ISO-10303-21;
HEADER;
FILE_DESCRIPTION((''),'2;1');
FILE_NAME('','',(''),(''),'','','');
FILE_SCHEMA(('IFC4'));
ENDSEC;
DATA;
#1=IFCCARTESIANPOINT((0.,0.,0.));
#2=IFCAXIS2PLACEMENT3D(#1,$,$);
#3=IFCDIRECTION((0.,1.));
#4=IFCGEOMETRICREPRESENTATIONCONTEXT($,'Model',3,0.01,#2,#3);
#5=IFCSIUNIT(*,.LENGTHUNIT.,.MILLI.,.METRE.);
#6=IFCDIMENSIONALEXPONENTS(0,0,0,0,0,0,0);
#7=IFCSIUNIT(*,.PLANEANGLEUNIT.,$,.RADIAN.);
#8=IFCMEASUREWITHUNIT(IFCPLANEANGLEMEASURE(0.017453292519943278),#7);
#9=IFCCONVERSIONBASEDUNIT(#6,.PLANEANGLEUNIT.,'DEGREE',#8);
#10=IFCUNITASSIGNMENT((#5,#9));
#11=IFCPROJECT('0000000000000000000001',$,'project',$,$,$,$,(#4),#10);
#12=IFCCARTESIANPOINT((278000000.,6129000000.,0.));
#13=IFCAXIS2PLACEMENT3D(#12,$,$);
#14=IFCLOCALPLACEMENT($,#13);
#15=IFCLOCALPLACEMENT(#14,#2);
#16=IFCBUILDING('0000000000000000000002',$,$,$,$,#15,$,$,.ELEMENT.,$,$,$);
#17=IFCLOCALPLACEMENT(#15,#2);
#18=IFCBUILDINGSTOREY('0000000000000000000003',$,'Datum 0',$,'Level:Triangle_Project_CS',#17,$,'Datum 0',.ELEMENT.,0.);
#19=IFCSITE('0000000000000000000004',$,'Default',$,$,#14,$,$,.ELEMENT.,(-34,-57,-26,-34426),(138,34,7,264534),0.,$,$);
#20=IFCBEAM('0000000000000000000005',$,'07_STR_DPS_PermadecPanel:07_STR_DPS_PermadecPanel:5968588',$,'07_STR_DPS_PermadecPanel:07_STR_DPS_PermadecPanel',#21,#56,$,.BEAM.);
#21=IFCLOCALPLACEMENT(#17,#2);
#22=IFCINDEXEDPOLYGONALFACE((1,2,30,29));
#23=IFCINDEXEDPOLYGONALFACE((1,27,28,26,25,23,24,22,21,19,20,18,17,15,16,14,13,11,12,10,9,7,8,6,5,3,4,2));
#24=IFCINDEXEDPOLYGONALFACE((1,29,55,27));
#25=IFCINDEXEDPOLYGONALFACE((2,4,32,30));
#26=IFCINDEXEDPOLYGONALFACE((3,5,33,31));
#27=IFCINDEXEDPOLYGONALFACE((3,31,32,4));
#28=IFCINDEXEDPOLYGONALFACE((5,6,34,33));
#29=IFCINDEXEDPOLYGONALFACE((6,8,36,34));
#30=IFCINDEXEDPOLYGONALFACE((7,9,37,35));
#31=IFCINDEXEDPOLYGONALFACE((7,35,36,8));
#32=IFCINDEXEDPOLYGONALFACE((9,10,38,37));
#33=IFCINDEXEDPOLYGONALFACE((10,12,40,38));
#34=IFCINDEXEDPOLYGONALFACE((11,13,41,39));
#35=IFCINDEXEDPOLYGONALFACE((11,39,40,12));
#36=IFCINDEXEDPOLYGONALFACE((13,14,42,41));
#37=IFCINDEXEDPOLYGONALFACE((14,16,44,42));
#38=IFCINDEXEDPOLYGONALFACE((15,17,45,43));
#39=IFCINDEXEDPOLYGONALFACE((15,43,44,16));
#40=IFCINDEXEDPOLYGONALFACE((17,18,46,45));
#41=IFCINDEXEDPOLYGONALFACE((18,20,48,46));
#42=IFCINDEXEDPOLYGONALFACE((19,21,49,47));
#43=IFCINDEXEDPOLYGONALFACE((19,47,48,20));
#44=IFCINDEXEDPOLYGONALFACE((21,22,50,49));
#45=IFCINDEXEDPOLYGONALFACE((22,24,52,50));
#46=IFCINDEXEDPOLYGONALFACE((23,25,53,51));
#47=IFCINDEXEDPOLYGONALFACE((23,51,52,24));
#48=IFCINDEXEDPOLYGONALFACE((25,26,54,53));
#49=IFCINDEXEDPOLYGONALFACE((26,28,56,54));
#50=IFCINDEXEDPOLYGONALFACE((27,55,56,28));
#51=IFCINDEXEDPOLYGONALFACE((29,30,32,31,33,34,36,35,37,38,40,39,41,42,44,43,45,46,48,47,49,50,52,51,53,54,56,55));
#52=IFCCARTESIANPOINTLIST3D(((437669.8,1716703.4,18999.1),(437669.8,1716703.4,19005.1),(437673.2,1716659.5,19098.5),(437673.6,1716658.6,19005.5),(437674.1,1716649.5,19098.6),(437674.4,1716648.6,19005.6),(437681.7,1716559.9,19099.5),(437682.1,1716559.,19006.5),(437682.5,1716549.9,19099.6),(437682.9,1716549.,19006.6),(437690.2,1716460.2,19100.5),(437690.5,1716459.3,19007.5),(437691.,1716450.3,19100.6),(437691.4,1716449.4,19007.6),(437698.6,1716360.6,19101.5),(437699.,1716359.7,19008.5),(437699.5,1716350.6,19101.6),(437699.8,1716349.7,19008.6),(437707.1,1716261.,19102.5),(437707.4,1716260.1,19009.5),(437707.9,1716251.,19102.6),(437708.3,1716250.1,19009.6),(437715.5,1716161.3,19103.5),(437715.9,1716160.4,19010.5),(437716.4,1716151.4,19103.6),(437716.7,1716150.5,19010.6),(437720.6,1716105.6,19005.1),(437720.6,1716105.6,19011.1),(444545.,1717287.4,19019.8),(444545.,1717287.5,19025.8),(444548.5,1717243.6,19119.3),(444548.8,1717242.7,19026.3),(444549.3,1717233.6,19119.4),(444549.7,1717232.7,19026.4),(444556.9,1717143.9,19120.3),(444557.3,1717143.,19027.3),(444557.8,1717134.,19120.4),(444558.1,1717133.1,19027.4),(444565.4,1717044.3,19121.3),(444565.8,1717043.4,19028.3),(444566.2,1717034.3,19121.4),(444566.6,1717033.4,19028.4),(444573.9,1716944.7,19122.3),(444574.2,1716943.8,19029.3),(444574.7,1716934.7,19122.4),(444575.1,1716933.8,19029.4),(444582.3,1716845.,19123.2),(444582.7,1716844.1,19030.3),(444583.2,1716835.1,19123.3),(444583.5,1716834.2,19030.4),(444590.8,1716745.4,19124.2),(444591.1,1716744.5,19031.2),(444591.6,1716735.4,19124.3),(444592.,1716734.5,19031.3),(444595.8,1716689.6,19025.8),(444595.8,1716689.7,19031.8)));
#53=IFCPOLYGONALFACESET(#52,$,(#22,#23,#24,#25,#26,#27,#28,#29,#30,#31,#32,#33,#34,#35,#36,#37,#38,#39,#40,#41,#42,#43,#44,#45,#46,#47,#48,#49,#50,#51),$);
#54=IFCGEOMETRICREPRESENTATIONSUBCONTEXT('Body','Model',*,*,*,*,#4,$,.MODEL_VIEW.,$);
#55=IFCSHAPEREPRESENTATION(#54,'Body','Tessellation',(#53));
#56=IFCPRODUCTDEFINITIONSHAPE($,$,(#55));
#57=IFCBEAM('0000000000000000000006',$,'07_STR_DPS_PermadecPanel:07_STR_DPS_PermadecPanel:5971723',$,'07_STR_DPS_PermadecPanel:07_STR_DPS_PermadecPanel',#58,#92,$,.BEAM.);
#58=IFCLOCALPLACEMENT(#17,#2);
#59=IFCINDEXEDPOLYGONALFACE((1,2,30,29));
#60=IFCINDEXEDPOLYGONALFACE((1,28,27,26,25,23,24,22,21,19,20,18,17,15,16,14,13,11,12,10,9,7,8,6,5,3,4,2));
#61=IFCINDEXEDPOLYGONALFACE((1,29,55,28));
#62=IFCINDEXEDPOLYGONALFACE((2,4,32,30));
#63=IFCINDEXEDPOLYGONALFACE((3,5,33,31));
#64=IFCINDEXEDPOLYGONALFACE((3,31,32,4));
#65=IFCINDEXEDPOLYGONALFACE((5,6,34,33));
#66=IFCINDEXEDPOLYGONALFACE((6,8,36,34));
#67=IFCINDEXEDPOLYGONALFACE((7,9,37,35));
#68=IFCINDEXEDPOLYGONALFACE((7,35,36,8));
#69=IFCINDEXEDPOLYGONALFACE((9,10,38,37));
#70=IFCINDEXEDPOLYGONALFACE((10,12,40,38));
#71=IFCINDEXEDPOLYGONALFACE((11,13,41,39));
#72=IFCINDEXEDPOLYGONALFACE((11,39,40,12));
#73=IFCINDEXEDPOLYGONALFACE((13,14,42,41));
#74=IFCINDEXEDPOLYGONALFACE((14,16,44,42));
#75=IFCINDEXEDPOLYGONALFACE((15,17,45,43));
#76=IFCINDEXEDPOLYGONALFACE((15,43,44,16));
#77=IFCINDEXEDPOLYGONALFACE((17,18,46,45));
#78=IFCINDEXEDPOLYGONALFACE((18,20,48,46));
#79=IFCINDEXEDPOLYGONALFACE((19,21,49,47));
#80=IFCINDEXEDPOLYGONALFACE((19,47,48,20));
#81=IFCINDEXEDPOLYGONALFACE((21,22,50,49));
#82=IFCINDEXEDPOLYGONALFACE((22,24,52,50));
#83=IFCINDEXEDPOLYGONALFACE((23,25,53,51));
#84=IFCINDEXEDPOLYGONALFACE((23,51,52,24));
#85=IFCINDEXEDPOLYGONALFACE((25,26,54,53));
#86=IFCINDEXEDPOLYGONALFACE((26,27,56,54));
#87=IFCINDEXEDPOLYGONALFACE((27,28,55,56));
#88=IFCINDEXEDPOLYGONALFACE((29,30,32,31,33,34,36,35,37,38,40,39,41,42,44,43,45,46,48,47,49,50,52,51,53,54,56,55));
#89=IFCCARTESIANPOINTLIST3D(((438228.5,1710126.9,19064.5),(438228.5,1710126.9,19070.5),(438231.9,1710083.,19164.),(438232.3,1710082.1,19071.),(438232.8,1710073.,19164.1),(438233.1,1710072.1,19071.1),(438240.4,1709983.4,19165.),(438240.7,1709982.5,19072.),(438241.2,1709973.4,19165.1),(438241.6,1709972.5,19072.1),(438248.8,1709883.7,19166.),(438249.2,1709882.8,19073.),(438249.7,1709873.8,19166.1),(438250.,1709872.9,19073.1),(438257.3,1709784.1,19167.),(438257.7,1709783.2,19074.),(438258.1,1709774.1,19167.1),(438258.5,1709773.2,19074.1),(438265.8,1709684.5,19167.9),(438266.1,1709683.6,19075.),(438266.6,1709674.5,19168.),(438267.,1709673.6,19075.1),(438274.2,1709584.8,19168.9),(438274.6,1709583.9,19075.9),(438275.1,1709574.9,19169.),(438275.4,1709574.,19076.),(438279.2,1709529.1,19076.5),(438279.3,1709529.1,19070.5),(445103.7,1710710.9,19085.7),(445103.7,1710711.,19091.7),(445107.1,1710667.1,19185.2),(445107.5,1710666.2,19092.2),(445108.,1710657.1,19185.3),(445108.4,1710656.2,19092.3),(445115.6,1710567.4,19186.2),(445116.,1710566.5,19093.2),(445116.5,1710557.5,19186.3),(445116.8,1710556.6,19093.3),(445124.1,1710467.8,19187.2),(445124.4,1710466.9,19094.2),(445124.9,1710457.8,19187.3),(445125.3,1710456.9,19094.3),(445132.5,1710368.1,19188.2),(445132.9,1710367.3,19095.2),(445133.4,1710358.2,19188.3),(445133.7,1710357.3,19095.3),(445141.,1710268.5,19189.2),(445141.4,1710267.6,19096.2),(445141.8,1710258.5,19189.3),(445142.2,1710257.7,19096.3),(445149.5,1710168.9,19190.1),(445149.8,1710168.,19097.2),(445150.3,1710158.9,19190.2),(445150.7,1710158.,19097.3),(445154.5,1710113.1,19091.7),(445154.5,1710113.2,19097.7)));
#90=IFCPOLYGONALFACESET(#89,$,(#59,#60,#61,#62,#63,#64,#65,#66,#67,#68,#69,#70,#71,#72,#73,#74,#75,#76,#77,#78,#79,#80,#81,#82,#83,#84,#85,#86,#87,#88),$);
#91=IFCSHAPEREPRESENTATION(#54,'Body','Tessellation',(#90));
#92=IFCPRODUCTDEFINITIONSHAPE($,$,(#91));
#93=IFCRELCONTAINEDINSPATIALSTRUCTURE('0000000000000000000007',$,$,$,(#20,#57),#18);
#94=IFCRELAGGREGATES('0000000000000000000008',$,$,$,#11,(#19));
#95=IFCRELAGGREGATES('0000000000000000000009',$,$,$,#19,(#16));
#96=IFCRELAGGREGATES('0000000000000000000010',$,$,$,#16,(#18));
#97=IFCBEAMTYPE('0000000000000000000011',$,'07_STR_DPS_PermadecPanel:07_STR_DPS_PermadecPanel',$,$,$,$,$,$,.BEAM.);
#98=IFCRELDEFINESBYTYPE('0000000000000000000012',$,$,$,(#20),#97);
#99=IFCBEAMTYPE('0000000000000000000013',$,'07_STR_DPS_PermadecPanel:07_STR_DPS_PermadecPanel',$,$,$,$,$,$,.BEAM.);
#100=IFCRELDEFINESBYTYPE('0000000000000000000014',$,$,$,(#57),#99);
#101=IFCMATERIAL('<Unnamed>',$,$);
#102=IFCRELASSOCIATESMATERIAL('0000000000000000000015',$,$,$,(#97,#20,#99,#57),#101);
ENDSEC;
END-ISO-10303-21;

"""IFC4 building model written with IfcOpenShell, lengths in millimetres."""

from ifc_helpers import new_model, entity, si_unit, converted_unit, direction, frame, origin, place, context, subcontext, project, spatial, indexed_curve, outline, extrude, source, transform, mapped, material, type_object, type_shapes, element, save


model = new_model("IFC4")

# Units and contexts
model_context = context("Model", 3, precision=0.01, world=origin(), true_north=direction((0.0, 1.0)))
body_context = subcontext(model_context, "Body", "Model", "MODEL_VIEW")
ifc_project = project(units=[si_unit("LENGTHUNIT", "METRE", prefix="MILLI"), converted_unit("PLANEANGLEUNIT", "DEGREE", entity("IfcPlaneAngleMeasure", 0.017453292519943278), si_unit("PLANEANGLEUNIT", "RADIAN"), dimensions=[0, 0, 0, 0, 0, 0, 0])], contexts=[model_context])

# Site, building, storey
site_placement = place(None, frame((278000000.0, 6129000000.0, 0.0)))
site = spatial("IfcSite", under=ifc_project, at=site_placement, Name="Default", CompositionType="ELEMENT", RefLatitude=(-34, -57, -26, -34426), RefLongitude=(138, 34, 7, 264534), RefElevation=0.0)
building_placement = place(site_placement, origin())
building = spatial("IfcBuilding", under=site, at=building_placement, CompositionType="ELEMENT")
storey_placement = place(building_placement, frame((0.0, 0.0, 0.0)))
storey = spatial("IfcBuildingStorey", under=building, at=storey_placement, Name="Datum 0", ObjectType="Level:Triangle_Project_CS", LongName="Datum 0", CompositionType="ELEMENT", Elevation=0.0)

# Beams
ifc_material = material(Name="<Unnamed>")
beam_type_1 = type_object("IfcBeamType", Name="07_STR_DPS_PermadecPanel:07_STR_DPS_PermadecPanel", PredefinedType="BEAM", material=ifc_material)
shared_shape_1 = source(origin(), body_context, "Body", "SweptSolid", [
    extrude(outline(indexed_curve([(-300.0, -45.4), (300.0, -45.4), (300.0, -39.4), (255.0, -39.4), (255.0, 53.6), (245.0, 53.6), (245.0, -39.4), (155.0, -39.4), (155.0, 53.6), (145.0, 53.6), (145.0, -39.4), (55.0, -39.4), (55.0, 53.6), (45.0, 53.6), (45.0, -39.4), (-45.0, -39.4), (-45.0, 53.6), (-55.0, 53.6), (-55.0, -39.4), (-145.0, -39.4), (-145.0, 53.6), (-155.0, 53.6), (-155.0, -39.4), (-245.0, -39.4), (-245.0, 53.6), (-255.0, 53.6), (-255.0, -39.4), (-300.0, -39.4), (-300.0, -45.4)], self_intersect=False)), frame((-3450.0, 0.0, 45.4), z_axis=(1.0, 0.0, 0.0), x_axis=(0.0, 1.0, 0.0)), (0.0, 0.0, 1.0), 6900.0),
])
type_shapes(beam_type_1, [shared_shape_1])
beam_1_placement = place(storey_placement, frame((441132.8, 1716696.5, 19012.4), z_axis=(-0.003837, 0.009663, 0.999946), x_axis=(-0.996407, -0.084646, -0.003005)))
element("IfcBeam", 1, at=beam_1_placement, inside=storey, type_object=beam_type_1, material=ifc_material, Name="07_STR_DPS_PermadecPanel:07_STR_DPS_PermadecPanel:5968588", ObjectType="07_STR_DPS_PermadecPanel:07_STR_DPS_PermadecPanel", PredefinedType="BEAM", context=body_context, shape_type="MappedRepresentation", body=[
    mapped(shared_shape_1, transform((0.0, 0.0, 0.0), scale=1.0)),
])
beam_type_2 = type_object("IfcBeamType", Name="07_STR_DPS_PermadecPanel:07_STR_DPS_PermadecPanel", PredefinedType="BEAM", material=ifc_material)
shared_shape_2 = source(origin(), body_context, "Body", "SweptSolid", [
    extrude(outline(indexed_curve([(-300.0, -45.4), (300.0, -45.4), (300.0, -39.4), (255.0, -39.4), (255.0, 53.6), (245.0, 53.6), (245.0, -39.4), (155.0, -39.4), (155.0, 53.6), (145.0, 53.6), (145.0, -39.4), (55.0, -39.4), (55.0, 53.6), (45.0, 53.6), (45.0, -39.4), (-45.0, -39.4), (-45.0, 53.6), (-55.0, 53.6), (-55.0, -39.4), (-145.0, -39.4), (-145.0, 53.6), (-155.0, 53.6), (-155.0, -39.4), (-245.0, -39.4), (-245.0, 53.6), (-255.0, 53.6), (-255.0, -39.4), (-300.0, -39.4), (-300.0, -45.4)], self_intersect=False)), frame((-3450.0, 0.0, 45.4), z_axis=(1.0, 0.0, 0.0), x_axis=(0.0, 1.0, 0.0)), (0.0, 0.0, 1.0), 6900.0),
])
type_shapes(beam_type_2, [shared_shape_2])
for number, where, z_axis, x_axis, name in (
    (2, (441691.5, 1710120.0, 19078.1), (-0.003904, 0.009657, 0.999946), (-0.996406, -0.084646, -0.003073), "07_STR_DPS_PermadecPanel:07_STR_DPS_PermadecPanel:5971723"),
):
    element("IfcBeam", number, at=place(storey_placement, frame(where, z_axis=z_axis, x_axis=x_axis)), inside=storey, type_object=beam_type_2, material=ifc_material, Name=name, ObjectType="07_STR_DPS_PermadecPanel:07_STR_DPS_PermadecPanel", PredefinedType="BEAM", context=body_context, shape_type="MappedRepresentation", body=[
        mapped(shared_shape_2, transform((0.0, 0.0, 0.0), scale=1.0)),
    ])

save(model, "model.ifc")
